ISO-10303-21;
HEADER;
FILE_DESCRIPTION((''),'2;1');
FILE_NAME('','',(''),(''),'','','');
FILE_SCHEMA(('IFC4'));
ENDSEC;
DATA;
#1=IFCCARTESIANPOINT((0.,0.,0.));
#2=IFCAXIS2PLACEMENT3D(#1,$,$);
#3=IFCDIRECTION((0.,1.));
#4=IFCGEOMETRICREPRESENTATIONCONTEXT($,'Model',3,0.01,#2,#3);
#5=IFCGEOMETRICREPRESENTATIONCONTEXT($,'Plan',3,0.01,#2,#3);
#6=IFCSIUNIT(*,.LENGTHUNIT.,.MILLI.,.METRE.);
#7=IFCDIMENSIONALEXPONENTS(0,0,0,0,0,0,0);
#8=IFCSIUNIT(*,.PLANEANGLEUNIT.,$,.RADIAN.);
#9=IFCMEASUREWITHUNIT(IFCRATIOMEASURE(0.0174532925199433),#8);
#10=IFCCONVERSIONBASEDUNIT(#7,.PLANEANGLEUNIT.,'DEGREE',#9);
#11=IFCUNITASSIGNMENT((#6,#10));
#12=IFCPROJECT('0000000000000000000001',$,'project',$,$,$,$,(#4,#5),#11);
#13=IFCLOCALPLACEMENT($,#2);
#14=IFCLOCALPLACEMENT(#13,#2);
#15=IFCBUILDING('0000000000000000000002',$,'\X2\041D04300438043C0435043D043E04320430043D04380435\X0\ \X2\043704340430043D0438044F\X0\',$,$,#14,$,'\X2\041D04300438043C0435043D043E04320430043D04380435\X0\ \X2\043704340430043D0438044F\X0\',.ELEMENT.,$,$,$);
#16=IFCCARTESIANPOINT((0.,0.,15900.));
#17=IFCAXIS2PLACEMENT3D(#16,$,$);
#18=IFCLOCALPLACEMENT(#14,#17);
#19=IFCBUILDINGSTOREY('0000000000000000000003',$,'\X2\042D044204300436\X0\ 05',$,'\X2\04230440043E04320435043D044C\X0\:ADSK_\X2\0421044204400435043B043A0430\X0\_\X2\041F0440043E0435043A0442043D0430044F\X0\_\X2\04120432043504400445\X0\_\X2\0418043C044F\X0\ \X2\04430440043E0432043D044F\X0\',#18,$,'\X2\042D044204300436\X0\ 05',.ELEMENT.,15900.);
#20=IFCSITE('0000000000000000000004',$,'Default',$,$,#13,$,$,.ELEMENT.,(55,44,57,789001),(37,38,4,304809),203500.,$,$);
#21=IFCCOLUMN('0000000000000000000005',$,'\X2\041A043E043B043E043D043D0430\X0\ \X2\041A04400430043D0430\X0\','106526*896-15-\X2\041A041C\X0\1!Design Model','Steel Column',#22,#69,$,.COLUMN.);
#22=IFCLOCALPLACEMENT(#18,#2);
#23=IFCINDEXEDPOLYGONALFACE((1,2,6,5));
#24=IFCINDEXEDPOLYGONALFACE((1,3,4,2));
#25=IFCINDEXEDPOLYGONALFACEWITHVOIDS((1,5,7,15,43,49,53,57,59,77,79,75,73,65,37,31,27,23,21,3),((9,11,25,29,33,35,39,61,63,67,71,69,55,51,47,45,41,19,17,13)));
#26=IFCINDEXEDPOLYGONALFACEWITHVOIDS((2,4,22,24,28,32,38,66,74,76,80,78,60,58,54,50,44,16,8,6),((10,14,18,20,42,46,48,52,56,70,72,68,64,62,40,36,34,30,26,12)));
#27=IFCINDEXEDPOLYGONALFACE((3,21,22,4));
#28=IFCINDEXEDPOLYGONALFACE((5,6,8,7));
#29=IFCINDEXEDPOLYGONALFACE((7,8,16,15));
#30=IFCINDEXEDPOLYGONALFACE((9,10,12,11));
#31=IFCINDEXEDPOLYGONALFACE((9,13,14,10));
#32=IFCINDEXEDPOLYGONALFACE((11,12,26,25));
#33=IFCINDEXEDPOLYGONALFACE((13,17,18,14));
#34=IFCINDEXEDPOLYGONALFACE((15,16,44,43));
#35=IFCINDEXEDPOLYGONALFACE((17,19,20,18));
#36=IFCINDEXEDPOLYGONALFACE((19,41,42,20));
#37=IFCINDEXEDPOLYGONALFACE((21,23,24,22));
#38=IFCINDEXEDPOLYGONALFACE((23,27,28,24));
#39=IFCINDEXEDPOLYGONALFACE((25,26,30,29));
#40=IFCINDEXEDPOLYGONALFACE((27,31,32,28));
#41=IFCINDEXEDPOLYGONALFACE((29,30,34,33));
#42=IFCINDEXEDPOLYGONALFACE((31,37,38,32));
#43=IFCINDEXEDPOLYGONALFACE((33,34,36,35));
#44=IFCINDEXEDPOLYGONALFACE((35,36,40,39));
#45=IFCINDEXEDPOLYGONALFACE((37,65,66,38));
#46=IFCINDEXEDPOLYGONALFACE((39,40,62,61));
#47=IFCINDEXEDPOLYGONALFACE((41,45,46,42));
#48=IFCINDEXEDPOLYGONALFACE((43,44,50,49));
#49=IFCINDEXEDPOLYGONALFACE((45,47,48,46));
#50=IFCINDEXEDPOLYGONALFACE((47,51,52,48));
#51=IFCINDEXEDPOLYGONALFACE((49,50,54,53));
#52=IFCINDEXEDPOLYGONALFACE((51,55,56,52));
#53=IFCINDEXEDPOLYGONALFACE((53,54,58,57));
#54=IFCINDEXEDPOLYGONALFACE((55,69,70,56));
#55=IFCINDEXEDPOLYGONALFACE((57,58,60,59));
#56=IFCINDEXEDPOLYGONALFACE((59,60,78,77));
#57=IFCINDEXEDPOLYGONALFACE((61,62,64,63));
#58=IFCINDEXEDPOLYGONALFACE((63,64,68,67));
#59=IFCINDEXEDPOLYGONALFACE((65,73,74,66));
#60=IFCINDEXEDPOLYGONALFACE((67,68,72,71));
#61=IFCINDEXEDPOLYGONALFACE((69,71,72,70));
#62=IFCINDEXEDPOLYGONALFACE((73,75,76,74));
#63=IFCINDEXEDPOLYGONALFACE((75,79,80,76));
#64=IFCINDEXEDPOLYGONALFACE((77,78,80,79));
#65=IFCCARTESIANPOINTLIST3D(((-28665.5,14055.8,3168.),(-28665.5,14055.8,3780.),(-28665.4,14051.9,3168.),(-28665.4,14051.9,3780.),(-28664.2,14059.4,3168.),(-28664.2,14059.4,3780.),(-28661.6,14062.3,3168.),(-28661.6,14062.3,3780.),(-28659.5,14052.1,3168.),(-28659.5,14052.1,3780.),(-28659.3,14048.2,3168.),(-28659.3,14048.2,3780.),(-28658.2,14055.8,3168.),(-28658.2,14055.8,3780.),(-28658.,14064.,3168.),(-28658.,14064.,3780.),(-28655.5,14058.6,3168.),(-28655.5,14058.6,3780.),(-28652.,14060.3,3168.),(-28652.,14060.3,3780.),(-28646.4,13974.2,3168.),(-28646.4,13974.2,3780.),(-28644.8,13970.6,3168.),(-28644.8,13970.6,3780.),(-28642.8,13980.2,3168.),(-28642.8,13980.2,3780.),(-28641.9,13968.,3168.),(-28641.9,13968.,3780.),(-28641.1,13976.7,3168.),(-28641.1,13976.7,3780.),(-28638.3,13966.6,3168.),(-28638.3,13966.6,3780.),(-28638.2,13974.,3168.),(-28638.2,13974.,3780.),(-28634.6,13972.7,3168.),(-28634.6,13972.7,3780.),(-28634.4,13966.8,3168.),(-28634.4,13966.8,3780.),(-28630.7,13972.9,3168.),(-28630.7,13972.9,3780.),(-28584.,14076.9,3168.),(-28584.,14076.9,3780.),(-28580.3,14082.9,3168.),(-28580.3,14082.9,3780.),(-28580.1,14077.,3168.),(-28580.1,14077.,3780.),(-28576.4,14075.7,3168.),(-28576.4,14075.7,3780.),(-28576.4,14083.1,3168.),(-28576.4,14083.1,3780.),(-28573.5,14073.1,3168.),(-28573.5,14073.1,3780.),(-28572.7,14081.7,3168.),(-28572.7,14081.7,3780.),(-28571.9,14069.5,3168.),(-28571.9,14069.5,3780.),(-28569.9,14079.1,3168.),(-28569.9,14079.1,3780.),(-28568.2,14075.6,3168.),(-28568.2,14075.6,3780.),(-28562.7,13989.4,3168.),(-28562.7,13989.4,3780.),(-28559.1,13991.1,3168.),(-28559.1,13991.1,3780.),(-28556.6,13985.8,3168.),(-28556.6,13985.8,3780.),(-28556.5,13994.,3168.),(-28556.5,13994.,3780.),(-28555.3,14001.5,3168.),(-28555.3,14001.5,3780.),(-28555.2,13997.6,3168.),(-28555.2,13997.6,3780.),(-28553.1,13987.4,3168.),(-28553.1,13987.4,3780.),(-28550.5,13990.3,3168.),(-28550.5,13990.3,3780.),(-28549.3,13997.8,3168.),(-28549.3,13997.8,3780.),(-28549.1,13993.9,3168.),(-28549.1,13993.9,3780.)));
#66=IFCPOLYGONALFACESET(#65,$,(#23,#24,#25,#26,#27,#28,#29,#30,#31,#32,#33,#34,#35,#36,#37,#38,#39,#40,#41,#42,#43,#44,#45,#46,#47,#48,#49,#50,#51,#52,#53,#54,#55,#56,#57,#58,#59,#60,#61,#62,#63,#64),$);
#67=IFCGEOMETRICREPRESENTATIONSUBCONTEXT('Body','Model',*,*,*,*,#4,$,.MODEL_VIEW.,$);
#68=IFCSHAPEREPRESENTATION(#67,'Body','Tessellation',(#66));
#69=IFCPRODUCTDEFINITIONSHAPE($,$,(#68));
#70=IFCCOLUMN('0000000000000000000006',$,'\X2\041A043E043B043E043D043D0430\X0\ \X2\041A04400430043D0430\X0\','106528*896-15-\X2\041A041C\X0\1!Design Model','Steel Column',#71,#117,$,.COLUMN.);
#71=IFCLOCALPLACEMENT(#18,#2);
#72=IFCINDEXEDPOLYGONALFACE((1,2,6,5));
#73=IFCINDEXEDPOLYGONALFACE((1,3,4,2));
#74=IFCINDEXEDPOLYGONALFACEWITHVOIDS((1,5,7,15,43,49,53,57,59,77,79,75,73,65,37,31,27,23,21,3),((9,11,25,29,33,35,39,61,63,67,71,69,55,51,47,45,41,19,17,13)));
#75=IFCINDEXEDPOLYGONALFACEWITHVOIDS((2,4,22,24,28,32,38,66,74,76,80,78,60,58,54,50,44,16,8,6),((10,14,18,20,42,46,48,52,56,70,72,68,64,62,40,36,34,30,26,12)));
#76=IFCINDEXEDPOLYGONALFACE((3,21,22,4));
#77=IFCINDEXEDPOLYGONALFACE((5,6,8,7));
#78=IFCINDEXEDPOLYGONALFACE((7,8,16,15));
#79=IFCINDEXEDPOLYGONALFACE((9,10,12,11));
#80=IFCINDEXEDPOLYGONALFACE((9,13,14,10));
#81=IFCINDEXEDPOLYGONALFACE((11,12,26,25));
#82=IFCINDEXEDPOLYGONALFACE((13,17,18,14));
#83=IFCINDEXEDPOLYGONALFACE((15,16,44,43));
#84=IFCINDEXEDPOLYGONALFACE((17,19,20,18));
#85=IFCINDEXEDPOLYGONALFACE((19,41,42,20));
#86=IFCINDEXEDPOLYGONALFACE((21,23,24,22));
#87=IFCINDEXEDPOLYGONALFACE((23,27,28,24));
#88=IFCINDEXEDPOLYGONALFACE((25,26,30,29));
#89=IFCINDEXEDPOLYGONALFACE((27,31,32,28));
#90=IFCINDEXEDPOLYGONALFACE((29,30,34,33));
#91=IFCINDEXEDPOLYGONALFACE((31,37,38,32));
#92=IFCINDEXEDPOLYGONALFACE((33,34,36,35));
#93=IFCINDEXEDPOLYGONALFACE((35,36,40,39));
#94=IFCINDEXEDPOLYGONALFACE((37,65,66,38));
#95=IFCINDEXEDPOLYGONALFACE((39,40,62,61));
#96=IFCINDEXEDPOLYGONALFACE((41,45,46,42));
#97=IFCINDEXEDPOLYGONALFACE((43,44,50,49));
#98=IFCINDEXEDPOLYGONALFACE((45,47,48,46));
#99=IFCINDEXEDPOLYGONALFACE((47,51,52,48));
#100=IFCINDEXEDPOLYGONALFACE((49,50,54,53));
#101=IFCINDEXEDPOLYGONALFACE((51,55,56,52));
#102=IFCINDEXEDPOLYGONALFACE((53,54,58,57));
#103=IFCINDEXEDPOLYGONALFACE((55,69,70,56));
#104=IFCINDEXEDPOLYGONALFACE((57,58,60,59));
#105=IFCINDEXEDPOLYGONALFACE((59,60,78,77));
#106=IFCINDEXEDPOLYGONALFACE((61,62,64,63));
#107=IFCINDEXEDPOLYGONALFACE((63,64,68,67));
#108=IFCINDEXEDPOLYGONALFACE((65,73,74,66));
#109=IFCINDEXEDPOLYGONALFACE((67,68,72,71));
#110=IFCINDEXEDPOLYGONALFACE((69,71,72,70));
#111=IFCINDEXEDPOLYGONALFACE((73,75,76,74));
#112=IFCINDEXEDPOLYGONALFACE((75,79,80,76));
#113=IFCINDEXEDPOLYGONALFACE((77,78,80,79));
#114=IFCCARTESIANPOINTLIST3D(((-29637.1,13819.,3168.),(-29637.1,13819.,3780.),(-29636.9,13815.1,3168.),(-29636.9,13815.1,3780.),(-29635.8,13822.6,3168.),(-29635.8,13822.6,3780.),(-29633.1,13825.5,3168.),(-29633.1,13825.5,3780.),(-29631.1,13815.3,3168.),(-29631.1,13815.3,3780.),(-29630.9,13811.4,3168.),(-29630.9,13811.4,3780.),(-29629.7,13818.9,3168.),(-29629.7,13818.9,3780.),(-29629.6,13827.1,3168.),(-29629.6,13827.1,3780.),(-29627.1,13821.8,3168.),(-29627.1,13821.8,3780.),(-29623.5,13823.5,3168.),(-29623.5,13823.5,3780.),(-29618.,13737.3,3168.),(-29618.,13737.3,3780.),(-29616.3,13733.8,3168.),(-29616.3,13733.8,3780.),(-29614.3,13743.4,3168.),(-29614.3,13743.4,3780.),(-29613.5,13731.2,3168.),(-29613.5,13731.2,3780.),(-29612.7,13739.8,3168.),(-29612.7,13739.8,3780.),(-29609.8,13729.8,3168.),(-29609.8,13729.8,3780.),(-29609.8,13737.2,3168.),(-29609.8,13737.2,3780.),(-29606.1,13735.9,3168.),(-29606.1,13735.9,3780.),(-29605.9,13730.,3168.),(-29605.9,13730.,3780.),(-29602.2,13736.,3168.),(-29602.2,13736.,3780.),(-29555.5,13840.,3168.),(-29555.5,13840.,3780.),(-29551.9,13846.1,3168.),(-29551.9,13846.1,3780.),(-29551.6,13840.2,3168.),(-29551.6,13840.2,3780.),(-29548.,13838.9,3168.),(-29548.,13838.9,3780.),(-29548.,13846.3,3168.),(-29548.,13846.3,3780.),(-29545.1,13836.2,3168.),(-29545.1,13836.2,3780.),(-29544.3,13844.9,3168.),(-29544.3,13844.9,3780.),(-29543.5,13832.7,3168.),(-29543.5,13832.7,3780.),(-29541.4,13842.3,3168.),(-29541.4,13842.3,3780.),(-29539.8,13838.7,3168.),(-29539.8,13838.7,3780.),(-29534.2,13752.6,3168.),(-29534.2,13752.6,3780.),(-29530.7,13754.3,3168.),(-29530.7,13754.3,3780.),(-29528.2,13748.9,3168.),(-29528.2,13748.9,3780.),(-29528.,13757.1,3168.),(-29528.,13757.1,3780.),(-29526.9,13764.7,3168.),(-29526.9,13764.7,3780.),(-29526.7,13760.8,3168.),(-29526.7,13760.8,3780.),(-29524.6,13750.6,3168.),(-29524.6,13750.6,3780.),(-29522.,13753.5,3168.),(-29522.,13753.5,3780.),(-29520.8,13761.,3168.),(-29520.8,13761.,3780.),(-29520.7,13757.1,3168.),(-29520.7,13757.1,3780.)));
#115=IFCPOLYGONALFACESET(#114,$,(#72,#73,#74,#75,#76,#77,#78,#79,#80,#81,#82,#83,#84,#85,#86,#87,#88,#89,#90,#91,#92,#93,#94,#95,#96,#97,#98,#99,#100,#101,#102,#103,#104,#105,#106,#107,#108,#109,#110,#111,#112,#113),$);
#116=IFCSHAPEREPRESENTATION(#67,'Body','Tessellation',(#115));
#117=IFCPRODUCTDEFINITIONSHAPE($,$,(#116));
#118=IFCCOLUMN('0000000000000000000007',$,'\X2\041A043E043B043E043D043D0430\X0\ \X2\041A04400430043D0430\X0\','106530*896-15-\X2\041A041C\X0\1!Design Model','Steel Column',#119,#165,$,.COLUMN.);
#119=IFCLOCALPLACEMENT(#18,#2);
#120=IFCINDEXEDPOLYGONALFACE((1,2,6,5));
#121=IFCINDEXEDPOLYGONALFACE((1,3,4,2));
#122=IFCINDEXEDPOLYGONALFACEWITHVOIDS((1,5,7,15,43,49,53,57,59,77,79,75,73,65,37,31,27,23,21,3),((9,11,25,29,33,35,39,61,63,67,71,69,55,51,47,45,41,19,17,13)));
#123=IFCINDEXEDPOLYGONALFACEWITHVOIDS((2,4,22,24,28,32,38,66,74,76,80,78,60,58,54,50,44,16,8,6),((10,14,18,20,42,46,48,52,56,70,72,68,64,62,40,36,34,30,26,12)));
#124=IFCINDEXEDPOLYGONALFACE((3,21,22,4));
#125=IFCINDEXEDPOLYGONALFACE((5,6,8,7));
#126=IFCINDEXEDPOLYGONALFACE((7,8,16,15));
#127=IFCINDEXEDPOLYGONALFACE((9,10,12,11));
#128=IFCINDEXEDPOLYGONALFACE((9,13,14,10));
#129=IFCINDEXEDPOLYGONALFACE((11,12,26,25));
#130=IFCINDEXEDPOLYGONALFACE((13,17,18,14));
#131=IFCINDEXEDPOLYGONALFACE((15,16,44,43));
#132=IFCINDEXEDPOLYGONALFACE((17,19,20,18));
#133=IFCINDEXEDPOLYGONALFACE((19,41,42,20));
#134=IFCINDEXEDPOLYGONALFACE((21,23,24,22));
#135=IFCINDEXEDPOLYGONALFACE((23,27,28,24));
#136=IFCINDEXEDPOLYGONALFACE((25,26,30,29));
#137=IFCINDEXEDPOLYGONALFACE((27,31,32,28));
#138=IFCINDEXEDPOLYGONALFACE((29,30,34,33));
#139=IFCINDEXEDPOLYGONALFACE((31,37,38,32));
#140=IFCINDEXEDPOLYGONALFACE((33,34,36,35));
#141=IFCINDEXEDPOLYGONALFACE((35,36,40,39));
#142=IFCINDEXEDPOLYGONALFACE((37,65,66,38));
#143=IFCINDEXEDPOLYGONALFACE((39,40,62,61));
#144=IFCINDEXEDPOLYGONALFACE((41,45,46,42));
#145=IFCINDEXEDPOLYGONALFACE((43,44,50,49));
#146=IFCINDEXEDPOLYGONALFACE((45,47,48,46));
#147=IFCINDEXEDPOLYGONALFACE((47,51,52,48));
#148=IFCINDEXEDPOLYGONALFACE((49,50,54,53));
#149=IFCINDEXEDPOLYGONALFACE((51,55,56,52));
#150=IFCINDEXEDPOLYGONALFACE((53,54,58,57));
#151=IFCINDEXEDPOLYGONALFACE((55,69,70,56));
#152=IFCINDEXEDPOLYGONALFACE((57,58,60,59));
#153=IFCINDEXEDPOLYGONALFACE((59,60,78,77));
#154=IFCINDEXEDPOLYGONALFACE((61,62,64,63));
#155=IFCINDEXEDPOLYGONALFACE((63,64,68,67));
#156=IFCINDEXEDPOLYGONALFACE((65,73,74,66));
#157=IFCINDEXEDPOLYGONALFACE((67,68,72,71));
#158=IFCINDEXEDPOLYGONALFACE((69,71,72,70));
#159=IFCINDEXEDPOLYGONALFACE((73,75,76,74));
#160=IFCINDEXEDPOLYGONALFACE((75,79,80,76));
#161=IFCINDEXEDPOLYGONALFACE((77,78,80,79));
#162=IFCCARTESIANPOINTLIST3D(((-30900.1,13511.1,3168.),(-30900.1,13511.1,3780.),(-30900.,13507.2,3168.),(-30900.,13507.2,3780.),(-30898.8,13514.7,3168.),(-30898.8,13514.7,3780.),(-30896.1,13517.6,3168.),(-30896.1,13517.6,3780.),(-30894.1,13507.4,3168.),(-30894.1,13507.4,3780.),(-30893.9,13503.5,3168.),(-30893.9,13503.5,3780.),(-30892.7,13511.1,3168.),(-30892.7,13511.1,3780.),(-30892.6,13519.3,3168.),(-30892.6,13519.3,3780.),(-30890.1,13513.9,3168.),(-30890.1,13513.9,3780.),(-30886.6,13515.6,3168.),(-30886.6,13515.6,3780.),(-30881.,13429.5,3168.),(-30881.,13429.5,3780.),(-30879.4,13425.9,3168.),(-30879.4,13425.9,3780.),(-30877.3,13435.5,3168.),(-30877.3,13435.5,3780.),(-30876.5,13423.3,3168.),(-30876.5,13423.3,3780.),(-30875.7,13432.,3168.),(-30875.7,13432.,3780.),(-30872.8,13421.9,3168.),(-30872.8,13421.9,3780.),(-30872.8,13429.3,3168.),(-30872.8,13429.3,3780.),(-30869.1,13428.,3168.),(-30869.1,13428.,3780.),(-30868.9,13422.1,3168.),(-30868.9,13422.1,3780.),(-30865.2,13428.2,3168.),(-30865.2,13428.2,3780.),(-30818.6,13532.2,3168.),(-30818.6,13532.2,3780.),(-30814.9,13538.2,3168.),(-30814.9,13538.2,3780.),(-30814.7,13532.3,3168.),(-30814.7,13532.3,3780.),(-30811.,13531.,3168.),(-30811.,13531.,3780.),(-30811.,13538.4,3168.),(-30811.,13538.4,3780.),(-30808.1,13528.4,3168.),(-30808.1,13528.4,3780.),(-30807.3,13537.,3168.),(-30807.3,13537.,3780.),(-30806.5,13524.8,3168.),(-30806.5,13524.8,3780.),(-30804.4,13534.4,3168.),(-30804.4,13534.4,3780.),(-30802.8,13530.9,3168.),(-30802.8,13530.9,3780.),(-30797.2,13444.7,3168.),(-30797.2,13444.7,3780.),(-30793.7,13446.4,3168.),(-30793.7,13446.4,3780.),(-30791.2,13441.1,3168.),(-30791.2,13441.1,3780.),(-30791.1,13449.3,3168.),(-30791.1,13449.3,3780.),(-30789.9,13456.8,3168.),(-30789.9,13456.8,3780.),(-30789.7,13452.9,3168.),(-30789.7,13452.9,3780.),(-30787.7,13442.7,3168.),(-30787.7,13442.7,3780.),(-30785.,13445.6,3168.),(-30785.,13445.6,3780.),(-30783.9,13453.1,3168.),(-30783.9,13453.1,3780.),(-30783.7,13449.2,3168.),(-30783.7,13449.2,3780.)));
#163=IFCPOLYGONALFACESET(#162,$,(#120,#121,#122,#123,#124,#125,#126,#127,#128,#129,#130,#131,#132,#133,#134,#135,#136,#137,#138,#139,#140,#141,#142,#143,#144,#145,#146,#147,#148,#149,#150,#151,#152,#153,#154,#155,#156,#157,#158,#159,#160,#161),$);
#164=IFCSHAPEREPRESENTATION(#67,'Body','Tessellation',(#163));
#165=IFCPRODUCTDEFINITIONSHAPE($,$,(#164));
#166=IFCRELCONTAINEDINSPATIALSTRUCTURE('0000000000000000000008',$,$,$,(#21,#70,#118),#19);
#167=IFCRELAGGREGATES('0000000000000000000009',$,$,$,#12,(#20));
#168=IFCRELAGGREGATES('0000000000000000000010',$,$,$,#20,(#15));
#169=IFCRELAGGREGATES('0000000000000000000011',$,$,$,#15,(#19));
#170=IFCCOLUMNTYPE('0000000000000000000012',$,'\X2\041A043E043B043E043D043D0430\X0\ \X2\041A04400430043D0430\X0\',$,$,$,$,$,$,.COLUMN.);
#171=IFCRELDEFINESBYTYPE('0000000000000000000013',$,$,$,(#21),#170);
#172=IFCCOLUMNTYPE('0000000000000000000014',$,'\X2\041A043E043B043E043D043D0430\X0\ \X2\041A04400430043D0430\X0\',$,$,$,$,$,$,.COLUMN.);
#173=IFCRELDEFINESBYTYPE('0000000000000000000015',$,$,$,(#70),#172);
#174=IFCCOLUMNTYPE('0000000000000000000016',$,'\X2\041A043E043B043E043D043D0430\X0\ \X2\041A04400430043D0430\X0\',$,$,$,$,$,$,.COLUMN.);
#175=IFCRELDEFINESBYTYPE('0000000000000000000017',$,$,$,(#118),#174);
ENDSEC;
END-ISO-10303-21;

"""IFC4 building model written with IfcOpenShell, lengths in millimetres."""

from ifc_helpers import new_model, entity, si_unit, converted_unit, direction, frame, origin, place, context, subcontext, project, spatial, indexed_curve, outline, extrude, type_object, element, save


model = new_model("IFC4")

# Units and contexts
model_context = context("Model", 3, precision=0.01, world=origin(), true_north=direction((0.0, 1.0)))
plan_context = context("Plan", 3, precision=0.01, world=origin(), true_north=direction((0.0, 1.0)))
body_context = subcontext(model_context, "Body", "Model", "MODEL_VIEW")
ifc_project = project(units=[si_unit("LENGTHUNIT", "METRE", prefix="MILLI"), converted_unit("PLANEANGLEUNIT", "DEGREE", entity("IfcRatioMeasure", 0.0174532925199433), si_unit("PLANEANGLEUNIT", "RADIAN"), dimensions=[0, 0, 0, 0, 0, 0, 0])], contexts=[model_context, plan_context])

# Site, building, storey
site_placement = place(None, origin())
site = spatial("IfcSite", under=ifc_project, at=site_placement, Name="Default", CompositionType="ELEMENT", RefLatitude=(55, 44, 57, 789001), RefLongitude=(37, 38, 4, 304809), RefElevation=203500.0)
building_placement = place(site_placement, origin())
building = spatial("IfcBuilding", under=site, at=building_placement, Name="Наименование здания", LongName="Наименование здания", CompositionType="ELEMENT")
storey_placement = place(building_placement, frame((0.0, 0.0, 15900.0)))
storey = spatial("IfcBuildingStorey", under=building, at=storey_placement, Name="Этаж 05", ObjectType="Уровень:ADSK_Стрелка_Проектная_Вверх_Имя уровня", LongName="Этаж 05", CompositionType="ELEMENT", Elevation=15900.0)

# Columns
column_type_1 = type_object("IfcColumnType", Name="Колонна Крана", PredefinedType="COLUMN")
column_1_placement = place(storey_placement, origin())
element("IfcColumn", 1, at=column_1_placement, inside=storey, type_object=column_type_1, Name="Колонна Крана", Description="106526*896-15-КМ1!Design Model", ObjectType="Steel Column", PredefinedType="COLUMN", context=body_context, shape_type="SweptSolid", body=[
    extrude(outline(indexed_curve([(29.5, -56.8), (33.4, -56.8), (37.0, -55.3), (39.7, -52.6), (41.2, -49.0), (56.8, 29.5), (56.8, 33.4), (55.3, 37.0), (52.6, 39.7), (49.0, 41.2), (-29.5, 56.8), (-33.4, 56.8), (-37.0, 55.3), (-39.7, 52.6), (-41.2, 49.0), (-56.8, -29.5), (-56.8, -33.4), (-55.3, -37.0), (-52.6, -39.7), (-49.0, -41.2), (29.5, -56.8)], self_intersect=False), holes=[indexed_curve([(-43.1, -37.3), (-46.7, -35.8), (-49.5, -33.1), (-51.0, -29.5), (-51.0, -25.5), (-37.3, 43.1), (-35.8, 46.7), (-33.1, 49.5), (-29.5, 51.0), (-25.5, 51.0), (43.1, 37.3), (46.7, 35.8), (49.5, 33.1), (51.0, 29.5), (51.0, 25.5), (37.3, -43.1), (35.8, -46.7), (33.1, -49.5), (29.5, -51.0), (25.5, -51.0), (-43.1, -37.3)], self_intersect=False)]), frame((-28607.3, 14024.9, 3168.0), z_axis=(0.0, 0.0, 1.0), x_axis=(0.906681, 0.421816, 0.0)), (0.0, 0.0, 1.0), 612.0),
])
column_type_2 = type_object("IfcColumnType", Name="Колонна Крана", PredefinedType="COLUMN")
column_2_placement = place(storey_placement, origin())
element("IfcColumn", 2, at=column_2_placement, inside=storey, type_object=column_type_2, Name="Колонна Крана", Description="106528*896-15-КМ1!Design Model", ObjectType="Steel Column", PredefinedType="COLUMN", context=body_context, shape_type="SweptSolid", body=[
    extrude(outline(indexed_curve([(29.5, -56.8), (33.4, -56.8), (37.0, -55.3), (39.7, -52.6), (41.2, -49.0), (56.8, 29.5), (56.8, 33.4), (55.3, 37.0), (52.6, 39.7), (49.0, 41.2), (-29.5, 56.8), (-33.4, 56.8), (-37.0, 55.3), (-39.7, 52.6), (-41.2, 49.0), (-56.8, -29.5), (-56.8, -33.4), (-55.3, -37.0), (-52.6, -39.7), (-49.0, -41.2), (29.5, -56.8)], self_intersect=False), holes=[indexed_curve([(-43.1, -37.3), (-46.7, -35.8), (-49.5, -33.1), (-51.0, -29.5), (-51.0, -25.5), (-37.3, 43.1), (-35.8, 46.7), (-33.1, 49.5), (-29.5, 51.0), (-25.5, 51.0), (43.1, 37.3), (46.7, 35.8), (49.5, 33.1), (51.0, 29.5), (51.0, 25.5), (37.3, -43.1), (35.8, -46.7), (33.1, -49.5), (29.5, -51.0), (25.5, -51.0), (-43.1, -37.3)], self_intersect=False)]), frame((-29578.9, 13788.0, 3168.0), z_axis=(0.0, 0.0, 1.0), x_axis=(0.906681, 0.421816, 0.0)), (0.0, 0.0, 1.0), 612.0),
])
column_type_3 = type_object("IfcColumnType", Name="Колонна Крана", PredefinedType="COLUMN")
column_3_placement = place(storey_placement, origin())
element("IfcColumn", 3, at=column_3_placement, inside=storey, type_object=column_type_3, Name="Колонна Крана", Description="106530*896-15-КМ1!Design Model", ObjectType="Steel Column", PredefinedType="COLUMN", context=body_context, shape_type="SweptSolid", body=[
    extrude(outline(indexed_curve([(29.5, -56.8), (33.4, -56.8), (37.0, -55.3), (39.7, -52.6), (41.2, -49.0), (56.8, 29.5), (56.8, 33.4), (55.3, 37.0), (52.6, 39.7), (49.0, 41.2), (-29.5, 56.8), (-33.4, 56.8), (-37.0, 55.3), (-39.7, 52.6), (-41.2, 49.0), (-56.8, -29.5), (-56.8, -33.4), (-55.3, -37.0), (-52.6, -39.7), (-49.0, -41.2), (29.5, -56.8)], self_intersect=False), holes=[indexed_curve([(-43.1, -37.3), (-46.7, -35.8), (-49.5, -33.1), (-51.0, -29.5), (-51.0, -25.5), (-37.3, 43.1), (-35.8, 46.7), (-33.1, 49.5), (-29.5, 51.0), (-25.5, 51.0), (43.1, 37.3), (46.7, 35.8), (49.5, 33.1), (51.0, 29.5), (51.0, 25.5), (37.3, -43.1), (35.8, -46.7), (33.1, -49.5), (29.5, -51.0), (25.5, -51.0), (-43.1, -37.3)], self_intersect=False)]), frame((-30841.9, 13480.2, 3168.0), z_axis=(0.0, 0.0, 1.0), x_axis=(0.906681, 0.421816, 0.0)), (0.0, 0.0, 1.0), 612.0),
])

save(model, "model.ifc")
